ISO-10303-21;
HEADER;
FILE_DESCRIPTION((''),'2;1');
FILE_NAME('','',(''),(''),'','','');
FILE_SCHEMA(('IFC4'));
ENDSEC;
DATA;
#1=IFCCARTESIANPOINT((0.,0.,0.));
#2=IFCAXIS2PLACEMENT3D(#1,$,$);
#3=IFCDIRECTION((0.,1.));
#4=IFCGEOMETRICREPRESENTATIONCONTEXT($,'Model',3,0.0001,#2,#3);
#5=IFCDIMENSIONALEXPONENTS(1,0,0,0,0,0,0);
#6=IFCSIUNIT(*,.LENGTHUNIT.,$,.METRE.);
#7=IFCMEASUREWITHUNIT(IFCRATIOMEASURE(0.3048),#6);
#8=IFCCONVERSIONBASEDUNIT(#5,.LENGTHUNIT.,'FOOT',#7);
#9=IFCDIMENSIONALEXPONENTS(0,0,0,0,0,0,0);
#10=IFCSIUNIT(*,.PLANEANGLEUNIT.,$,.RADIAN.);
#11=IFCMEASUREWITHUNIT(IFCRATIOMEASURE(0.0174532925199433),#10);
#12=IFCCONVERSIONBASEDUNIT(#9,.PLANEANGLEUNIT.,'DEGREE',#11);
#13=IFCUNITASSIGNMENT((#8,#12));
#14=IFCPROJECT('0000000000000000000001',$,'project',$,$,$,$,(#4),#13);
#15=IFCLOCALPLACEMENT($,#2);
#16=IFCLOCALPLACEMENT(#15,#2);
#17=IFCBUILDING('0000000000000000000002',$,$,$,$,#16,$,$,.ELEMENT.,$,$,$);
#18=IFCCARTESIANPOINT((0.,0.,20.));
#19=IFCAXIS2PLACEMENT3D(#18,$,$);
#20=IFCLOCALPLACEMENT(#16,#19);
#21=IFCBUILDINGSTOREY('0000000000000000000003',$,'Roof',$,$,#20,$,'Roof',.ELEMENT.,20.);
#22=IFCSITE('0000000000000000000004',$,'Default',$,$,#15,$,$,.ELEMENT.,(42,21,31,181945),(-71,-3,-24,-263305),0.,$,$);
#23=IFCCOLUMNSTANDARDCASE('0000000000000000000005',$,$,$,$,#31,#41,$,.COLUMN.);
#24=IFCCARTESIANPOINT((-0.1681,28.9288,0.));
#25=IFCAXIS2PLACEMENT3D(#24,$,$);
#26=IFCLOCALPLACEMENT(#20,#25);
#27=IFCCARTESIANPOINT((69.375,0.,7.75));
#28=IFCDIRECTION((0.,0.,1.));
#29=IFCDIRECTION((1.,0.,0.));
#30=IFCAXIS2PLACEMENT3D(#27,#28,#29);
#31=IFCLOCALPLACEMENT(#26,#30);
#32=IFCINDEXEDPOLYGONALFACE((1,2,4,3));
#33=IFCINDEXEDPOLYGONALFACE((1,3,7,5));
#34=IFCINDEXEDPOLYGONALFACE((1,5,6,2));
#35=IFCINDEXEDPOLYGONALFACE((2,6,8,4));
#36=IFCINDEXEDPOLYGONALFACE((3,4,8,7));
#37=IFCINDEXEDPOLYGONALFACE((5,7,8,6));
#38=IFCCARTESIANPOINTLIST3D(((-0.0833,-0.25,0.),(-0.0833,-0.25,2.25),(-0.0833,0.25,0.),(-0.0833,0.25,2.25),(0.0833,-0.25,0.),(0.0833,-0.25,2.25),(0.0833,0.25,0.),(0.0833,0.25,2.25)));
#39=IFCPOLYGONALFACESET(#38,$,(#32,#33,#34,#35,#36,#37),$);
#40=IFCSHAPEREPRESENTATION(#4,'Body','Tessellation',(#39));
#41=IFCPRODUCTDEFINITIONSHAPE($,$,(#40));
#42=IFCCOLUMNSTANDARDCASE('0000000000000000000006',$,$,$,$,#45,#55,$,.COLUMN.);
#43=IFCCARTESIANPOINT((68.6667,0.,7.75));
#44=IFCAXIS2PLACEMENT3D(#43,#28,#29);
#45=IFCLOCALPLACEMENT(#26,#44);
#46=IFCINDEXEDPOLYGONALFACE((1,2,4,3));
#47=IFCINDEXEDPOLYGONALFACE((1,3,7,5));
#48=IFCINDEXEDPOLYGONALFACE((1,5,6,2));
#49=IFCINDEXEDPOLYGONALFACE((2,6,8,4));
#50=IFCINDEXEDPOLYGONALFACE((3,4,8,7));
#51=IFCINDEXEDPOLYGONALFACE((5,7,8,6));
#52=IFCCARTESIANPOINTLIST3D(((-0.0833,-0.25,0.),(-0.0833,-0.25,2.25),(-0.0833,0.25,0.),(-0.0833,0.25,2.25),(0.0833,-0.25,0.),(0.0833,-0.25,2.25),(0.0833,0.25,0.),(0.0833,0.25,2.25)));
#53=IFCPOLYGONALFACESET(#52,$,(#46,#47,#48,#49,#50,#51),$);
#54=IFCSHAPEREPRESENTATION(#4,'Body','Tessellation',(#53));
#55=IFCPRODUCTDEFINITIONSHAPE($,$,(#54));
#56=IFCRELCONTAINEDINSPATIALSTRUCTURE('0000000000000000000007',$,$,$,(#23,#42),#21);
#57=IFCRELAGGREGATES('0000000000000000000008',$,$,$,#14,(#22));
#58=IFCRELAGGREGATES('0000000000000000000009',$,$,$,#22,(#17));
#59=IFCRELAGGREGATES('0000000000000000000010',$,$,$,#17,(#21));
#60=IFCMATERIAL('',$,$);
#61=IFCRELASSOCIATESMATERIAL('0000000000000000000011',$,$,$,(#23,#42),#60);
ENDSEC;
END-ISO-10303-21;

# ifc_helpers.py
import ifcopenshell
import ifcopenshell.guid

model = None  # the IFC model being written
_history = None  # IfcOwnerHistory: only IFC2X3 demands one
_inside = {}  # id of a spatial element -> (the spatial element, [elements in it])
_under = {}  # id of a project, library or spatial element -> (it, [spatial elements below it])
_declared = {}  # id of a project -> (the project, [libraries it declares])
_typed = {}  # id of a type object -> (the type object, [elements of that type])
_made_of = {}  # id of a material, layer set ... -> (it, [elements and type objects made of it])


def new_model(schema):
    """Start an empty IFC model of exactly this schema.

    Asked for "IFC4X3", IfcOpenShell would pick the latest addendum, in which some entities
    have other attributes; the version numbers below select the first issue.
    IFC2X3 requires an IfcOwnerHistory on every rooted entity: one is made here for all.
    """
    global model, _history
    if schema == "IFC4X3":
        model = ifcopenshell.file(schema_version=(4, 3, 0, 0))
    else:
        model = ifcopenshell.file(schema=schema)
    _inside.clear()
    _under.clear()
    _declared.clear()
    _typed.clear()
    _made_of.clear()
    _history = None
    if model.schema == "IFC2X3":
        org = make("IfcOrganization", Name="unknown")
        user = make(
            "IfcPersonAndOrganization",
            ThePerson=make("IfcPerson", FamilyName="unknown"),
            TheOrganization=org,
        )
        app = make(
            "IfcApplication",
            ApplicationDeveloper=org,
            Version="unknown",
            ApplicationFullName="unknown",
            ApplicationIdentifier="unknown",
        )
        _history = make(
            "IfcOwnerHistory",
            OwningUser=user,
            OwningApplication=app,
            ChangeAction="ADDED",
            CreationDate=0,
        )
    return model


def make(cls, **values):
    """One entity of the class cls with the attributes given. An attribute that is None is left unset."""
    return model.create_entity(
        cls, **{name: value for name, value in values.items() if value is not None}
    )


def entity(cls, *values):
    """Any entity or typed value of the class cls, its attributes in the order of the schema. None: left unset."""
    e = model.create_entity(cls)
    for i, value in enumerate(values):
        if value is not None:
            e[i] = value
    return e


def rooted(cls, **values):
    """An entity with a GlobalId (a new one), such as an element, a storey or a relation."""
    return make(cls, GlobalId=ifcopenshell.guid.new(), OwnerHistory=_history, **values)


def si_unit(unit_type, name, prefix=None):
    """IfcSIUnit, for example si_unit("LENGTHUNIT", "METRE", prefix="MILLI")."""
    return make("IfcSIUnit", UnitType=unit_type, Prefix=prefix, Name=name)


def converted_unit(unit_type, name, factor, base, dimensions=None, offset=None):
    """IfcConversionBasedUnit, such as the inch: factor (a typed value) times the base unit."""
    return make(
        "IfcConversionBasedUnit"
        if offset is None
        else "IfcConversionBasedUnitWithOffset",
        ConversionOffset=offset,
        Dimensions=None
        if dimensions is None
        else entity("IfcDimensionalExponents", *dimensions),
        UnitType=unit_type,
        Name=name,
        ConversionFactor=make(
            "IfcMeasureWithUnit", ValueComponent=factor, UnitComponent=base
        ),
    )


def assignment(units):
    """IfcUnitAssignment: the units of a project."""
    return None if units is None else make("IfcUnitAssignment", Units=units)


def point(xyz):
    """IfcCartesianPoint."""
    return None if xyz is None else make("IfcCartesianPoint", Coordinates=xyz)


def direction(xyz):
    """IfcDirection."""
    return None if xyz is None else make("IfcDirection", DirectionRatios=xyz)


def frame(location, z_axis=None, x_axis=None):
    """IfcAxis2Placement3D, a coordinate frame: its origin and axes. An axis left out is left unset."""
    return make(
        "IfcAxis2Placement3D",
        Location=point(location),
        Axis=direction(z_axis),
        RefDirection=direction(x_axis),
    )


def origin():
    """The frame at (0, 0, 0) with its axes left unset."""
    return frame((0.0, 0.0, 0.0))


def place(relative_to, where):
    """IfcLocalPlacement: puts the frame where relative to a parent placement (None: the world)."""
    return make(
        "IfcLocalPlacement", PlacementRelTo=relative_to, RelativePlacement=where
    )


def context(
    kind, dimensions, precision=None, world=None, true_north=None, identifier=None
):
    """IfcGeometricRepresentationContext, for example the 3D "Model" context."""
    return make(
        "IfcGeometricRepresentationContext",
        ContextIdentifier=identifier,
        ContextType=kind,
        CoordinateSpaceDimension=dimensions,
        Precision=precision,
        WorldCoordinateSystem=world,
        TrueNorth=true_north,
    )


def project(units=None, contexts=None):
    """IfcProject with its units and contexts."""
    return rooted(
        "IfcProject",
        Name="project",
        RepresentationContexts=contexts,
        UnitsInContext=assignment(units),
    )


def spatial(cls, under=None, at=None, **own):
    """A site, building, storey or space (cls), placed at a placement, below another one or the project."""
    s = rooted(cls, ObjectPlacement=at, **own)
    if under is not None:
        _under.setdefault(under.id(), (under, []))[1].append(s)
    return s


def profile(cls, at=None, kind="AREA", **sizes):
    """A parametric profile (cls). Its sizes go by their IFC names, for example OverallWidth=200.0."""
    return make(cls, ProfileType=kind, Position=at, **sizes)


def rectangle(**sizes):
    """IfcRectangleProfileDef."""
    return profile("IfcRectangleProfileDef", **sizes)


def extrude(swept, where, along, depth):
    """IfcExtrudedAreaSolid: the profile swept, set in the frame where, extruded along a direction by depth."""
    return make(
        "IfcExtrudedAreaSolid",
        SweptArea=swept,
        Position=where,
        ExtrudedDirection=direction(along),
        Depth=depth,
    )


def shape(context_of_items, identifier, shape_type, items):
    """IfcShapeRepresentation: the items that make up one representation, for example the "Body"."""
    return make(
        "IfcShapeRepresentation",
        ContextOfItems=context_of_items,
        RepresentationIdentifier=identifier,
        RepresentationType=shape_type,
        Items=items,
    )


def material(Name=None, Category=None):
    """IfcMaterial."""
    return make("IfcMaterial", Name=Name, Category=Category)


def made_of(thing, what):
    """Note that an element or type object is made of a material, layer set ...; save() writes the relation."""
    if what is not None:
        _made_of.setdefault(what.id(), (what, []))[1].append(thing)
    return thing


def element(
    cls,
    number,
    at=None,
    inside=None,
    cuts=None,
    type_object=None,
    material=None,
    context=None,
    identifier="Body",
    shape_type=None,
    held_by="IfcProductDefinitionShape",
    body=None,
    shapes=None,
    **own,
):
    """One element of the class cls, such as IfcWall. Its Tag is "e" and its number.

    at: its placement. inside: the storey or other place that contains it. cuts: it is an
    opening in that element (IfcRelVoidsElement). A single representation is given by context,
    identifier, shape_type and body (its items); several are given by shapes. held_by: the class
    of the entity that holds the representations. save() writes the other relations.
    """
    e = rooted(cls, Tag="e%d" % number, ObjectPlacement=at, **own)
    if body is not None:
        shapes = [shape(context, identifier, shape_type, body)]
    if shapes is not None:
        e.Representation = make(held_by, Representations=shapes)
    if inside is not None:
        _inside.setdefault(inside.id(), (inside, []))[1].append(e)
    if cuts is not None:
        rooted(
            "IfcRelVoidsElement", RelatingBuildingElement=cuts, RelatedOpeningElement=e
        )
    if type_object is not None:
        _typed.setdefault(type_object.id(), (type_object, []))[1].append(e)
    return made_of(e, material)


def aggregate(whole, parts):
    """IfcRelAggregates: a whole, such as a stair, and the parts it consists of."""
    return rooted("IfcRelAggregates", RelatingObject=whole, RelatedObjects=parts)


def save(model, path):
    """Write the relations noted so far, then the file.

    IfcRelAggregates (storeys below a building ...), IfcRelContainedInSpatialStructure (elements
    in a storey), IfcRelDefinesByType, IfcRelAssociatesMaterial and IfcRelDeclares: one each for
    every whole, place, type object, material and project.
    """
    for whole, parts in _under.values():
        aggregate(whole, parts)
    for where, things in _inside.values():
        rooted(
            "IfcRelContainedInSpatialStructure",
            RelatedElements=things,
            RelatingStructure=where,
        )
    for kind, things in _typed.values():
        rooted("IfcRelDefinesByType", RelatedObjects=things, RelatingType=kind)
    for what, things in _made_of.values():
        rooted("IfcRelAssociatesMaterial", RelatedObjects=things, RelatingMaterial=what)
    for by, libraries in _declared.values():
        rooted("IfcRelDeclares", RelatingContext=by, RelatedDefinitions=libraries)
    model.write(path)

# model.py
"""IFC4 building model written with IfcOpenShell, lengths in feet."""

from ifc_helpers import new_model, entity, si_unit, converted_unit, direction, frame, origin, place, context, project, spatial, rectangle, extrude, material, element, save


model = new_model("IFC4")

# Units and contexts
model_context = context("Model", 3, precision=0.0001, world=origin(), true_north=direction((0.0, 1.0)))
ifc_project = project(units=[converted_unit("LENGTHUNIT", "FOOT", entity("IfcRatioMeasure", 0.3048), si_unit("LENGTHUNIT", "METRE"), dimensions=[1, 0, 0, 0, 0, 0, 0]), converted_unit("PLANEANGLEUNIT", "DEGREE", entity("IfcRatioMeasure", 0.0174532925199433), si_unit("PLANEANGLEUNIT", "RADIAN"), dimensions=[0, 0, 0, 0, 0, 0, 0])], contexts=[model_context])

# Site, building, storey
site_placement = place(None, origin())
site = spatial("IfcSite", under=ifc_project, at=site_placement, Name="Default", CompositionType="ELEMENT", RefLatitude=(42, 21, 31, 181945), RefLongitude=(-71, -3, -24, -263305), RefElevation=0.0)
building_placement = place(site_placement, origin())
building = spatial("IfcBuilding", under=site, at=building_placement, CompositionType="ELEMENT")
storey_placement = place(building_placement, frame((0.0, 0.0, 20.0)))
storey = spatial("IfcBuildingStorey", under=building, at=storey_placement, Name="Roof", LongName="Roof", CompositionType="ELEMENT", Elevation=20.0)

# Columns
ifc_material = material(Name="")
placement = place(storey_placement, frame((-0.1681, 28.9288, 0.0)))
for number, where, z_axis, x_axis in (
    (1, (69.375, 0.0, 7.75), (0.0, 0.0, 1.0), (1.0, 0.0, 0.0)),
    (2, (68.6667, 0.0, 7.75), (0.0, 0.0, 1.0), (1.0, 0.0, 0.0)),
):
    element("IfcColumnStandardCase", number, at=place(placement, frame(where, z_axis=z_axis, x_axis=x_axis)), inside=storey, material=ifc_material, PredefinedType="COLUMN", context=model_context, shape_type="SweptSolid", body=[
        extrude(rectangle(XDim=0.1667, YDim=0.5), origin(), (0.0, 0.0, 1.0), 2.25),
    ])

save(model, "model.ifc")
